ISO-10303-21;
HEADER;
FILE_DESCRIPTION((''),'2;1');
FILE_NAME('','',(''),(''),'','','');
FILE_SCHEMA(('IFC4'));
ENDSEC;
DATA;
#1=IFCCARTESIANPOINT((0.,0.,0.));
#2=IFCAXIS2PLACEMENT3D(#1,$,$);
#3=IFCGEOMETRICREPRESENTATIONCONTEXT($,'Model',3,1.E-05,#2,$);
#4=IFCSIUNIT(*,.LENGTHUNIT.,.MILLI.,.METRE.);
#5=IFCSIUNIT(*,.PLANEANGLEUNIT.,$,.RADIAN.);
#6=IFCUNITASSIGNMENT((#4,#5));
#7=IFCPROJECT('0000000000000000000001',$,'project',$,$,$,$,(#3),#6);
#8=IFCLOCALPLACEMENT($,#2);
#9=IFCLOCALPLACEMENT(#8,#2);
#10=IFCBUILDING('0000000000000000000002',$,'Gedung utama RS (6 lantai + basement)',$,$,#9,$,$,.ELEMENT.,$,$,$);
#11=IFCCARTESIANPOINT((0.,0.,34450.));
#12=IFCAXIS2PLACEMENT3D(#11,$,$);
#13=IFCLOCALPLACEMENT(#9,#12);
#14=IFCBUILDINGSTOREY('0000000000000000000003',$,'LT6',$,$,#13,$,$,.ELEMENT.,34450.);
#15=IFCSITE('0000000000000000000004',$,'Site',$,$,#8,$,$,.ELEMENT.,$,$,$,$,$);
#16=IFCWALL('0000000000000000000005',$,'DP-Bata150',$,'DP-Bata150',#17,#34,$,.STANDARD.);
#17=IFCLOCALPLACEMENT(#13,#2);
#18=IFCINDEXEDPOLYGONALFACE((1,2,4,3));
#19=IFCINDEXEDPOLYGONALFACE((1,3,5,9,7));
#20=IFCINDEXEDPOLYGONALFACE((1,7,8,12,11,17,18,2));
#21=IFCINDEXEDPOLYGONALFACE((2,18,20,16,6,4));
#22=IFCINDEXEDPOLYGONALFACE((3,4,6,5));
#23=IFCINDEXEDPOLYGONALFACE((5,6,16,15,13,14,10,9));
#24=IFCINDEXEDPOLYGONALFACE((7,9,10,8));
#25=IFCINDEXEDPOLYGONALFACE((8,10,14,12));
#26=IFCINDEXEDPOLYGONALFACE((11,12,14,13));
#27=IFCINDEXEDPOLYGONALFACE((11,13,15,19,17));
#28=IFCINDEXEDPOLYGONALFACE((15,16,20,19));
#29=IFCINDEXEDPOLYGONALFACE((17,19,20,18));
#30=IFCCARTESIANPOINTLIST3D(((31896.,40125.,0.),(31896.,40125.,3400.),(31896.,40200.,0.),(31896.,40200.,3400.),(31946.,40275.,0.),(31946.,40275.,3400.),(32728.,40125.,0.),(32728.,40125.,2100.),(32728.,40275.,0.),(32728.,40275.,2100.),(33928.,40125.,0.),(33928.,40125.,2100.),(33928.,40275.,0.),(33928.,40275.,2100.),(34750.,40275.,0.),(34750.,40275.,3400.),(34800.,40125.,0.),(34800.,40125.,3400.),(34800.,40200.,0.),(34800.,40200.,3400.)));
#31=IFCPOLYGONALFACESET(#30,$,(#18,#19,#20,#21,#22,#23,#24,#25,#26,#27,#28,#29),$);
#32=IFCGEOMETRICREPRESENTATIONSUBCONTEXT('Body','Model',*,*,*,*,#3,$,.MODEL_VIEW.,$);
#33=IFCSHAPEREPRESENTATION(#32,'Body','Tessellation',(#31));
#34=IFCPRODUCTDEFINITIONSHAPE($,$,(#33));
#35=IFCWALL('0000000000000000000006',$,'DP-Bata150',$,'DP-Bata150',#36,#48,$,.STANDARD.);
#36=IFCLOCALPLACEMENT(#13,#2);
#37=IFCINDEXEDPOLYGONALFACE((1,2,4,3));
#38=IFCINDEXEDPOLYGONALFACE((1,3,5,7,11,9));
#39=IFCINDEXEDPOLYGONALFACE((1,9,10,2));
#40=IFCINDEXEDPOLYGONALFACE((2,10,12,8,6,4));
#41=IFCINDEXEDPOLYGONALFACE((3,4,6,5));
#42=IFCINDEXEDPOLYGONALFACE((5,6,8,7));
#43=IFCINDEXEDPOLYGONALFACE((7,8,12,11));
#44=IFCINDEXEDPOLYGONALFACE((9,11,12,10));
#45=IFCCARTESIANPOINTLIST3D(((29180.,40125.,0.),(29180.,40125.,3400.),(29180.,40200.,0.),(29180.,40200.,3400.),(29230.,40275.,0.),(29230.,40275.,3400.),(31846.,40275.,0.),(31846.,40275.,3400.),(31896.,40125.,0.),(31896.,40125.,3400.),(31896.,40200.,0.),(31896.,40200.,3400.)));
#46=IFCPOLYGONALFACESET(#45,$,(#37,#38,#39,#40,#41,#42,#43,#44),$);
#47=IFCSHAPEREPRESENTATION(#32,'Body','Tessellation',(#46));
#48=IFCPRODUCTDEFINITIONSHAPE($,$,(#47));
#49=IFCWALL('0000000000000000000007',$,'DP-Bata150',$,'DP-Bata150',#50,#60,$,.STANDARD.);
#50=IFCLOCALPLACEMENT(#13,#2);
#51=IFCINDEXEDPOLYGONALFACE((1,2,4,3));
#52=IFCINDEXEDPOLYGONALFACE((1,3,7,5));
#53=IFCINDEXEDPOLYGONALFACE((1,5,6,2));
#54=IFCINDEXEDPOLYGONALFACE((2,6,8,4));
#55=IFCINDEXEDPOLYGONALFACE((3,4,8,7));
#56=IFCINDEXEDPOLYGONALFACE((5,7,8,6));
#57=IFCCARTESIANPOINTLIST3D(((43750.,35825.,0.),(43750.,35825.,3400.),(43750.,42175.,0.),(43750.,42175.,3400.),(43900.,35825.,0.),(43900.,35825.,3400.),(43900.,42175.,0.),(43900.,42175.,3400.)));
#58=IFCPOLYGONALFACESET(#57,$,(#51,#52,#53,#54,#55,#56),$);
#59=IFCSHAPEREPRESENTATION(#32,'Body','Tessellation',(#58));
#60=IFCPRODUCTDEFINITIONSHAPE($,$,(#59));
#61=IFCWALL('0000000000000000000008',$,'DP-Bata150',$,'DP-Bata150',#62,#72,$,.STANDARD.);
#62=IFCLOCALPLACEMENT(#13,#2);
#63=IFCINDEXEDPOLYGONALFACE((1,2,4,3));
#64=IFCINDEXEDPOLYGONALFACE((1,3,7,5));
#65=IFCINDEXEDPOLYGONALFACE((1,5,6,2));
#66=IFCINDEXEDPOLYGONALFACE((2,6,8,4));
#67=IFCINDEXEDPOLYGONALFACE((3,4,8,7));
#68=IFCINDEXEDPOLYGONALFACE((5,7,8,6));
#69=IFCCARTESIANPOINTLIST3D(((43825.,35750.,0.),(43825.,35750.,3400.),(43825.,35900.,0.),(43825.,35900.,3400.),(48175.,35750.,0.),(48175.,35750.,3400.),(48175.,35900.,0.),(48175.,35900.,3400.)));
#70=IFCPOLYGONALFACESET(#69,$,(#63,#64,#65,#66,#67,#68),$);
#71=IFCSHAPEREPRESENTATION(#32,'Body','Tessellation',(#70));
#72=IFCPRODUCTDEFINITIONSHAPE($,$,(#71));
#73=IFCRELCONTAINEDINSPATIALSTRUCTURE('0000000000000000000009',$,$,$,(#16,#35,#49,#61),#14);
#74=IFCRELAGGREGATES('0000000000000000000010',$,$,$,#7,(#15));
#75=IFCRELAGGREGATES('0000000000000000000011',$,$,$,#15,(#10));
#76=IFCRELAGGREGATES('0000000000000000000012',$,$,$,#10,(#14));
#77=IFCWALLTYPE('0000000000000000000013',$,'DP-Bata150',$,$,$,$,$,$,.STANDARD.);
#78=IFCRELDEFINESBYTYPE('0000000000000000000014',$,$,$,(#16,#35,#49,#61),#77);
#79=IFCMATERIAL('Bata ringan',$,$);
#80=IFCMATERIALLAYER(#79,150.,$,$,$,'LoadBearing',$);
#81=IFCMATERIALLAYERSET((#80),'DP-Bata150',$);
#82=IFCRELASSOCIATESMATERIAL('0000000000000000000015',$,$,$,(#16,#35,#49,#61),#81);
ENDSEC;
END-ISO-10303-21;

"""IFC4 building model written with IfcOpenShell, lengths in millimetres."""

from ifc_helpers import new_model, si_unit, frame, frame_2d, origin, place, context, subcontext, project, spatial, polyline, rectangle, outline, extrude, material, layer, layer_set, layer_usage, type_object, element, save


model = new_model("IFC4")

# Units and contexts
model_context = context("Model", 3, precision=1e-05, world=origin())
body_context = subcontext(model_context, "Body", "Model", "MODEL_VIEW")
ifc_project = project(units=[si_unit("LENGTHUNIT", "METRE", prefix="MILLI"), si_unit("PLANEANGLEUNIT", "RADIAN")], contexts=[model_context])

# Site, building, storey
site_placement = place(None, origin())
site = spatial("IfcSite", under=ifc_project, at=site_placement, Name="Site", CompositionType="ELEMENT")
building_placement = place(site_placement, origin())
building = spatial("IfcBuilding", under=site, at=building_placement, Name="Gedung utama RS (6 lantai + basement)", CompositionType="ELEMENT")
storey_placement = place(building_placement, frame((0.0, 0.0, 34450.0)))
storey = spatial("IfcBuildingStorey", under=building, at=storey_placement, Name="LT6", CompositionType="ELEMENT", Elevation=34450.0)

# Shared definitions
ifc_material_1 = material(Name="Bata ringan")

# Shared definitions
ifc_layer_1 = layer(ifc_material_1, 150.0, Category="LoadBearing")
ifc_layer_set_1 = layer_set([ifc_layer_1], Name="DP-Bata150")
ifc_layer_usage_1 = layer_usage(ifc_layer_set_1, "AXIS2", "NEGATIVE", 75.0)
wall_type_1 = type_object("IfcWallType", Name="DP-Bata150", PredefinedType="STANDARD")

# Wall, opening
wall_1_placement = place(storey_placement, frame((34800.0, 40200.0, 0.0), z_axis=(0.0, 0.0, 1.0), x_axis=(-1.0, 0.0, 0.0)))
wall_1 = element("IfcWall", 1, at=wall_1_placement, inside=storey, type_object=wall_type_1, material=ifc_layer_usage_1, Name="DP-Bata150", ObjectType="DP-Bata150", PredefinedType="STANDARD", context=body_context, shape_type="SweptSolid", body=[
    extrude(outline(polyline([(50.0, -75.0), (0.0, 0.0), (0.0, 75.0), (2904.0, 75.0), (2904.0, 0.0), (2854.0, -75.0), (50.0, -75.0)])), origin(), (0.0, 0.0, 1.0), 3400.0),
])
opening_1_placement = place(wall_1_placement, frame((872.0, 0.0, 0.0), z_axis=(0.0, 0.0, 1.0), x_axis=(1.0, 0.0, 0.0)))
element("IfcOpeningElement", 2, at=opening_1_placement, cuts=wall_1, PredefinedType="OPENING", context=body_context, shape_type="SweptSolid", body=[
    extrude(rectangle(XDim=1200.0, YDim=170.0, at=frame_2d((600.0, 0.0))), origin(), (0.0, 0.0, 1.0), 2100.0),
])

# Walls
wall_2_placement = place(storey_placement, frame((31896.0, 40200.0, 0.0), z_axis=(0.0, 0.0, 1.0), x_axis=(-1.0, 0.0, 0.0)))
element("IfcWall", 3, at=wall_2_placement, inside=storey, type_object=wall_type_1, material=ifc_layer_usage_1, Name="DP-Bata150", ObjectType="DP-Bata150", PredefinedType="STANDARD", context=body_context, shape_type="SweptSolid", body=[
    extrude(outline(polyline([(50.0, -75.0), (0.0, 0.0), (0.0, 75.0), (2716.0, 75.0), (2716.0, 0.0), (2666.0, -75.0), (50.0, -75.0)])), origin(), (0.0, 0.0, 1.0), 3400.0),
])
wall_3_placement = place(storey_placement, frame((43825.0, 42175.0, 0.0), z_axis=(0.0, 0.0, 1.0), x_axis=(0.0, -1.0, 0.0)))
element("IfcWall", 4, at=wall_3_placement, inside=storey, type_object=wall_type_1, material=ifc_layer_usage_1, Name="DP-Bata150", ObjectType="DP-Bata150", PredefinedType="STANDARD", context=body_context, shape_type="SweptSolid", body=[
    extrude(outline(polyline([(0.0, -75.0), (0.0, 75.0), (6350.0, 75.0), (6350.0, -75.0), (0.0, -75.0)])), origin(), (0.0, 0.0, 1.0), 3400.0),
])
wall_4_placement = place(storey_placement, frame((43825.0, 35825.0, 0.0), z_axis=(0.0, 0.0, 1.0), x_axis=(1.0, 0.0, 0.0)))
element("IfcWall", 5, at=wall_4_placement, inside=storey, type_object=wall_type_1, material=ifc_layer_usage_1, Name="DP-Bata150", ObjectType="DP-Bata150", PredefinedType="STANDARD", context=body_context, shape_type="SweptSolid", body=[
    extrude(outline(polyline([(0.0, -75.0), (0.0, 75.0), (4350.0, 75.0), (4350.0, -75.0), (0.0, -75.0)])), origin(), (0.0, 0.0, 1.0), 3400.0),
])

save(model, "model.ifc")
